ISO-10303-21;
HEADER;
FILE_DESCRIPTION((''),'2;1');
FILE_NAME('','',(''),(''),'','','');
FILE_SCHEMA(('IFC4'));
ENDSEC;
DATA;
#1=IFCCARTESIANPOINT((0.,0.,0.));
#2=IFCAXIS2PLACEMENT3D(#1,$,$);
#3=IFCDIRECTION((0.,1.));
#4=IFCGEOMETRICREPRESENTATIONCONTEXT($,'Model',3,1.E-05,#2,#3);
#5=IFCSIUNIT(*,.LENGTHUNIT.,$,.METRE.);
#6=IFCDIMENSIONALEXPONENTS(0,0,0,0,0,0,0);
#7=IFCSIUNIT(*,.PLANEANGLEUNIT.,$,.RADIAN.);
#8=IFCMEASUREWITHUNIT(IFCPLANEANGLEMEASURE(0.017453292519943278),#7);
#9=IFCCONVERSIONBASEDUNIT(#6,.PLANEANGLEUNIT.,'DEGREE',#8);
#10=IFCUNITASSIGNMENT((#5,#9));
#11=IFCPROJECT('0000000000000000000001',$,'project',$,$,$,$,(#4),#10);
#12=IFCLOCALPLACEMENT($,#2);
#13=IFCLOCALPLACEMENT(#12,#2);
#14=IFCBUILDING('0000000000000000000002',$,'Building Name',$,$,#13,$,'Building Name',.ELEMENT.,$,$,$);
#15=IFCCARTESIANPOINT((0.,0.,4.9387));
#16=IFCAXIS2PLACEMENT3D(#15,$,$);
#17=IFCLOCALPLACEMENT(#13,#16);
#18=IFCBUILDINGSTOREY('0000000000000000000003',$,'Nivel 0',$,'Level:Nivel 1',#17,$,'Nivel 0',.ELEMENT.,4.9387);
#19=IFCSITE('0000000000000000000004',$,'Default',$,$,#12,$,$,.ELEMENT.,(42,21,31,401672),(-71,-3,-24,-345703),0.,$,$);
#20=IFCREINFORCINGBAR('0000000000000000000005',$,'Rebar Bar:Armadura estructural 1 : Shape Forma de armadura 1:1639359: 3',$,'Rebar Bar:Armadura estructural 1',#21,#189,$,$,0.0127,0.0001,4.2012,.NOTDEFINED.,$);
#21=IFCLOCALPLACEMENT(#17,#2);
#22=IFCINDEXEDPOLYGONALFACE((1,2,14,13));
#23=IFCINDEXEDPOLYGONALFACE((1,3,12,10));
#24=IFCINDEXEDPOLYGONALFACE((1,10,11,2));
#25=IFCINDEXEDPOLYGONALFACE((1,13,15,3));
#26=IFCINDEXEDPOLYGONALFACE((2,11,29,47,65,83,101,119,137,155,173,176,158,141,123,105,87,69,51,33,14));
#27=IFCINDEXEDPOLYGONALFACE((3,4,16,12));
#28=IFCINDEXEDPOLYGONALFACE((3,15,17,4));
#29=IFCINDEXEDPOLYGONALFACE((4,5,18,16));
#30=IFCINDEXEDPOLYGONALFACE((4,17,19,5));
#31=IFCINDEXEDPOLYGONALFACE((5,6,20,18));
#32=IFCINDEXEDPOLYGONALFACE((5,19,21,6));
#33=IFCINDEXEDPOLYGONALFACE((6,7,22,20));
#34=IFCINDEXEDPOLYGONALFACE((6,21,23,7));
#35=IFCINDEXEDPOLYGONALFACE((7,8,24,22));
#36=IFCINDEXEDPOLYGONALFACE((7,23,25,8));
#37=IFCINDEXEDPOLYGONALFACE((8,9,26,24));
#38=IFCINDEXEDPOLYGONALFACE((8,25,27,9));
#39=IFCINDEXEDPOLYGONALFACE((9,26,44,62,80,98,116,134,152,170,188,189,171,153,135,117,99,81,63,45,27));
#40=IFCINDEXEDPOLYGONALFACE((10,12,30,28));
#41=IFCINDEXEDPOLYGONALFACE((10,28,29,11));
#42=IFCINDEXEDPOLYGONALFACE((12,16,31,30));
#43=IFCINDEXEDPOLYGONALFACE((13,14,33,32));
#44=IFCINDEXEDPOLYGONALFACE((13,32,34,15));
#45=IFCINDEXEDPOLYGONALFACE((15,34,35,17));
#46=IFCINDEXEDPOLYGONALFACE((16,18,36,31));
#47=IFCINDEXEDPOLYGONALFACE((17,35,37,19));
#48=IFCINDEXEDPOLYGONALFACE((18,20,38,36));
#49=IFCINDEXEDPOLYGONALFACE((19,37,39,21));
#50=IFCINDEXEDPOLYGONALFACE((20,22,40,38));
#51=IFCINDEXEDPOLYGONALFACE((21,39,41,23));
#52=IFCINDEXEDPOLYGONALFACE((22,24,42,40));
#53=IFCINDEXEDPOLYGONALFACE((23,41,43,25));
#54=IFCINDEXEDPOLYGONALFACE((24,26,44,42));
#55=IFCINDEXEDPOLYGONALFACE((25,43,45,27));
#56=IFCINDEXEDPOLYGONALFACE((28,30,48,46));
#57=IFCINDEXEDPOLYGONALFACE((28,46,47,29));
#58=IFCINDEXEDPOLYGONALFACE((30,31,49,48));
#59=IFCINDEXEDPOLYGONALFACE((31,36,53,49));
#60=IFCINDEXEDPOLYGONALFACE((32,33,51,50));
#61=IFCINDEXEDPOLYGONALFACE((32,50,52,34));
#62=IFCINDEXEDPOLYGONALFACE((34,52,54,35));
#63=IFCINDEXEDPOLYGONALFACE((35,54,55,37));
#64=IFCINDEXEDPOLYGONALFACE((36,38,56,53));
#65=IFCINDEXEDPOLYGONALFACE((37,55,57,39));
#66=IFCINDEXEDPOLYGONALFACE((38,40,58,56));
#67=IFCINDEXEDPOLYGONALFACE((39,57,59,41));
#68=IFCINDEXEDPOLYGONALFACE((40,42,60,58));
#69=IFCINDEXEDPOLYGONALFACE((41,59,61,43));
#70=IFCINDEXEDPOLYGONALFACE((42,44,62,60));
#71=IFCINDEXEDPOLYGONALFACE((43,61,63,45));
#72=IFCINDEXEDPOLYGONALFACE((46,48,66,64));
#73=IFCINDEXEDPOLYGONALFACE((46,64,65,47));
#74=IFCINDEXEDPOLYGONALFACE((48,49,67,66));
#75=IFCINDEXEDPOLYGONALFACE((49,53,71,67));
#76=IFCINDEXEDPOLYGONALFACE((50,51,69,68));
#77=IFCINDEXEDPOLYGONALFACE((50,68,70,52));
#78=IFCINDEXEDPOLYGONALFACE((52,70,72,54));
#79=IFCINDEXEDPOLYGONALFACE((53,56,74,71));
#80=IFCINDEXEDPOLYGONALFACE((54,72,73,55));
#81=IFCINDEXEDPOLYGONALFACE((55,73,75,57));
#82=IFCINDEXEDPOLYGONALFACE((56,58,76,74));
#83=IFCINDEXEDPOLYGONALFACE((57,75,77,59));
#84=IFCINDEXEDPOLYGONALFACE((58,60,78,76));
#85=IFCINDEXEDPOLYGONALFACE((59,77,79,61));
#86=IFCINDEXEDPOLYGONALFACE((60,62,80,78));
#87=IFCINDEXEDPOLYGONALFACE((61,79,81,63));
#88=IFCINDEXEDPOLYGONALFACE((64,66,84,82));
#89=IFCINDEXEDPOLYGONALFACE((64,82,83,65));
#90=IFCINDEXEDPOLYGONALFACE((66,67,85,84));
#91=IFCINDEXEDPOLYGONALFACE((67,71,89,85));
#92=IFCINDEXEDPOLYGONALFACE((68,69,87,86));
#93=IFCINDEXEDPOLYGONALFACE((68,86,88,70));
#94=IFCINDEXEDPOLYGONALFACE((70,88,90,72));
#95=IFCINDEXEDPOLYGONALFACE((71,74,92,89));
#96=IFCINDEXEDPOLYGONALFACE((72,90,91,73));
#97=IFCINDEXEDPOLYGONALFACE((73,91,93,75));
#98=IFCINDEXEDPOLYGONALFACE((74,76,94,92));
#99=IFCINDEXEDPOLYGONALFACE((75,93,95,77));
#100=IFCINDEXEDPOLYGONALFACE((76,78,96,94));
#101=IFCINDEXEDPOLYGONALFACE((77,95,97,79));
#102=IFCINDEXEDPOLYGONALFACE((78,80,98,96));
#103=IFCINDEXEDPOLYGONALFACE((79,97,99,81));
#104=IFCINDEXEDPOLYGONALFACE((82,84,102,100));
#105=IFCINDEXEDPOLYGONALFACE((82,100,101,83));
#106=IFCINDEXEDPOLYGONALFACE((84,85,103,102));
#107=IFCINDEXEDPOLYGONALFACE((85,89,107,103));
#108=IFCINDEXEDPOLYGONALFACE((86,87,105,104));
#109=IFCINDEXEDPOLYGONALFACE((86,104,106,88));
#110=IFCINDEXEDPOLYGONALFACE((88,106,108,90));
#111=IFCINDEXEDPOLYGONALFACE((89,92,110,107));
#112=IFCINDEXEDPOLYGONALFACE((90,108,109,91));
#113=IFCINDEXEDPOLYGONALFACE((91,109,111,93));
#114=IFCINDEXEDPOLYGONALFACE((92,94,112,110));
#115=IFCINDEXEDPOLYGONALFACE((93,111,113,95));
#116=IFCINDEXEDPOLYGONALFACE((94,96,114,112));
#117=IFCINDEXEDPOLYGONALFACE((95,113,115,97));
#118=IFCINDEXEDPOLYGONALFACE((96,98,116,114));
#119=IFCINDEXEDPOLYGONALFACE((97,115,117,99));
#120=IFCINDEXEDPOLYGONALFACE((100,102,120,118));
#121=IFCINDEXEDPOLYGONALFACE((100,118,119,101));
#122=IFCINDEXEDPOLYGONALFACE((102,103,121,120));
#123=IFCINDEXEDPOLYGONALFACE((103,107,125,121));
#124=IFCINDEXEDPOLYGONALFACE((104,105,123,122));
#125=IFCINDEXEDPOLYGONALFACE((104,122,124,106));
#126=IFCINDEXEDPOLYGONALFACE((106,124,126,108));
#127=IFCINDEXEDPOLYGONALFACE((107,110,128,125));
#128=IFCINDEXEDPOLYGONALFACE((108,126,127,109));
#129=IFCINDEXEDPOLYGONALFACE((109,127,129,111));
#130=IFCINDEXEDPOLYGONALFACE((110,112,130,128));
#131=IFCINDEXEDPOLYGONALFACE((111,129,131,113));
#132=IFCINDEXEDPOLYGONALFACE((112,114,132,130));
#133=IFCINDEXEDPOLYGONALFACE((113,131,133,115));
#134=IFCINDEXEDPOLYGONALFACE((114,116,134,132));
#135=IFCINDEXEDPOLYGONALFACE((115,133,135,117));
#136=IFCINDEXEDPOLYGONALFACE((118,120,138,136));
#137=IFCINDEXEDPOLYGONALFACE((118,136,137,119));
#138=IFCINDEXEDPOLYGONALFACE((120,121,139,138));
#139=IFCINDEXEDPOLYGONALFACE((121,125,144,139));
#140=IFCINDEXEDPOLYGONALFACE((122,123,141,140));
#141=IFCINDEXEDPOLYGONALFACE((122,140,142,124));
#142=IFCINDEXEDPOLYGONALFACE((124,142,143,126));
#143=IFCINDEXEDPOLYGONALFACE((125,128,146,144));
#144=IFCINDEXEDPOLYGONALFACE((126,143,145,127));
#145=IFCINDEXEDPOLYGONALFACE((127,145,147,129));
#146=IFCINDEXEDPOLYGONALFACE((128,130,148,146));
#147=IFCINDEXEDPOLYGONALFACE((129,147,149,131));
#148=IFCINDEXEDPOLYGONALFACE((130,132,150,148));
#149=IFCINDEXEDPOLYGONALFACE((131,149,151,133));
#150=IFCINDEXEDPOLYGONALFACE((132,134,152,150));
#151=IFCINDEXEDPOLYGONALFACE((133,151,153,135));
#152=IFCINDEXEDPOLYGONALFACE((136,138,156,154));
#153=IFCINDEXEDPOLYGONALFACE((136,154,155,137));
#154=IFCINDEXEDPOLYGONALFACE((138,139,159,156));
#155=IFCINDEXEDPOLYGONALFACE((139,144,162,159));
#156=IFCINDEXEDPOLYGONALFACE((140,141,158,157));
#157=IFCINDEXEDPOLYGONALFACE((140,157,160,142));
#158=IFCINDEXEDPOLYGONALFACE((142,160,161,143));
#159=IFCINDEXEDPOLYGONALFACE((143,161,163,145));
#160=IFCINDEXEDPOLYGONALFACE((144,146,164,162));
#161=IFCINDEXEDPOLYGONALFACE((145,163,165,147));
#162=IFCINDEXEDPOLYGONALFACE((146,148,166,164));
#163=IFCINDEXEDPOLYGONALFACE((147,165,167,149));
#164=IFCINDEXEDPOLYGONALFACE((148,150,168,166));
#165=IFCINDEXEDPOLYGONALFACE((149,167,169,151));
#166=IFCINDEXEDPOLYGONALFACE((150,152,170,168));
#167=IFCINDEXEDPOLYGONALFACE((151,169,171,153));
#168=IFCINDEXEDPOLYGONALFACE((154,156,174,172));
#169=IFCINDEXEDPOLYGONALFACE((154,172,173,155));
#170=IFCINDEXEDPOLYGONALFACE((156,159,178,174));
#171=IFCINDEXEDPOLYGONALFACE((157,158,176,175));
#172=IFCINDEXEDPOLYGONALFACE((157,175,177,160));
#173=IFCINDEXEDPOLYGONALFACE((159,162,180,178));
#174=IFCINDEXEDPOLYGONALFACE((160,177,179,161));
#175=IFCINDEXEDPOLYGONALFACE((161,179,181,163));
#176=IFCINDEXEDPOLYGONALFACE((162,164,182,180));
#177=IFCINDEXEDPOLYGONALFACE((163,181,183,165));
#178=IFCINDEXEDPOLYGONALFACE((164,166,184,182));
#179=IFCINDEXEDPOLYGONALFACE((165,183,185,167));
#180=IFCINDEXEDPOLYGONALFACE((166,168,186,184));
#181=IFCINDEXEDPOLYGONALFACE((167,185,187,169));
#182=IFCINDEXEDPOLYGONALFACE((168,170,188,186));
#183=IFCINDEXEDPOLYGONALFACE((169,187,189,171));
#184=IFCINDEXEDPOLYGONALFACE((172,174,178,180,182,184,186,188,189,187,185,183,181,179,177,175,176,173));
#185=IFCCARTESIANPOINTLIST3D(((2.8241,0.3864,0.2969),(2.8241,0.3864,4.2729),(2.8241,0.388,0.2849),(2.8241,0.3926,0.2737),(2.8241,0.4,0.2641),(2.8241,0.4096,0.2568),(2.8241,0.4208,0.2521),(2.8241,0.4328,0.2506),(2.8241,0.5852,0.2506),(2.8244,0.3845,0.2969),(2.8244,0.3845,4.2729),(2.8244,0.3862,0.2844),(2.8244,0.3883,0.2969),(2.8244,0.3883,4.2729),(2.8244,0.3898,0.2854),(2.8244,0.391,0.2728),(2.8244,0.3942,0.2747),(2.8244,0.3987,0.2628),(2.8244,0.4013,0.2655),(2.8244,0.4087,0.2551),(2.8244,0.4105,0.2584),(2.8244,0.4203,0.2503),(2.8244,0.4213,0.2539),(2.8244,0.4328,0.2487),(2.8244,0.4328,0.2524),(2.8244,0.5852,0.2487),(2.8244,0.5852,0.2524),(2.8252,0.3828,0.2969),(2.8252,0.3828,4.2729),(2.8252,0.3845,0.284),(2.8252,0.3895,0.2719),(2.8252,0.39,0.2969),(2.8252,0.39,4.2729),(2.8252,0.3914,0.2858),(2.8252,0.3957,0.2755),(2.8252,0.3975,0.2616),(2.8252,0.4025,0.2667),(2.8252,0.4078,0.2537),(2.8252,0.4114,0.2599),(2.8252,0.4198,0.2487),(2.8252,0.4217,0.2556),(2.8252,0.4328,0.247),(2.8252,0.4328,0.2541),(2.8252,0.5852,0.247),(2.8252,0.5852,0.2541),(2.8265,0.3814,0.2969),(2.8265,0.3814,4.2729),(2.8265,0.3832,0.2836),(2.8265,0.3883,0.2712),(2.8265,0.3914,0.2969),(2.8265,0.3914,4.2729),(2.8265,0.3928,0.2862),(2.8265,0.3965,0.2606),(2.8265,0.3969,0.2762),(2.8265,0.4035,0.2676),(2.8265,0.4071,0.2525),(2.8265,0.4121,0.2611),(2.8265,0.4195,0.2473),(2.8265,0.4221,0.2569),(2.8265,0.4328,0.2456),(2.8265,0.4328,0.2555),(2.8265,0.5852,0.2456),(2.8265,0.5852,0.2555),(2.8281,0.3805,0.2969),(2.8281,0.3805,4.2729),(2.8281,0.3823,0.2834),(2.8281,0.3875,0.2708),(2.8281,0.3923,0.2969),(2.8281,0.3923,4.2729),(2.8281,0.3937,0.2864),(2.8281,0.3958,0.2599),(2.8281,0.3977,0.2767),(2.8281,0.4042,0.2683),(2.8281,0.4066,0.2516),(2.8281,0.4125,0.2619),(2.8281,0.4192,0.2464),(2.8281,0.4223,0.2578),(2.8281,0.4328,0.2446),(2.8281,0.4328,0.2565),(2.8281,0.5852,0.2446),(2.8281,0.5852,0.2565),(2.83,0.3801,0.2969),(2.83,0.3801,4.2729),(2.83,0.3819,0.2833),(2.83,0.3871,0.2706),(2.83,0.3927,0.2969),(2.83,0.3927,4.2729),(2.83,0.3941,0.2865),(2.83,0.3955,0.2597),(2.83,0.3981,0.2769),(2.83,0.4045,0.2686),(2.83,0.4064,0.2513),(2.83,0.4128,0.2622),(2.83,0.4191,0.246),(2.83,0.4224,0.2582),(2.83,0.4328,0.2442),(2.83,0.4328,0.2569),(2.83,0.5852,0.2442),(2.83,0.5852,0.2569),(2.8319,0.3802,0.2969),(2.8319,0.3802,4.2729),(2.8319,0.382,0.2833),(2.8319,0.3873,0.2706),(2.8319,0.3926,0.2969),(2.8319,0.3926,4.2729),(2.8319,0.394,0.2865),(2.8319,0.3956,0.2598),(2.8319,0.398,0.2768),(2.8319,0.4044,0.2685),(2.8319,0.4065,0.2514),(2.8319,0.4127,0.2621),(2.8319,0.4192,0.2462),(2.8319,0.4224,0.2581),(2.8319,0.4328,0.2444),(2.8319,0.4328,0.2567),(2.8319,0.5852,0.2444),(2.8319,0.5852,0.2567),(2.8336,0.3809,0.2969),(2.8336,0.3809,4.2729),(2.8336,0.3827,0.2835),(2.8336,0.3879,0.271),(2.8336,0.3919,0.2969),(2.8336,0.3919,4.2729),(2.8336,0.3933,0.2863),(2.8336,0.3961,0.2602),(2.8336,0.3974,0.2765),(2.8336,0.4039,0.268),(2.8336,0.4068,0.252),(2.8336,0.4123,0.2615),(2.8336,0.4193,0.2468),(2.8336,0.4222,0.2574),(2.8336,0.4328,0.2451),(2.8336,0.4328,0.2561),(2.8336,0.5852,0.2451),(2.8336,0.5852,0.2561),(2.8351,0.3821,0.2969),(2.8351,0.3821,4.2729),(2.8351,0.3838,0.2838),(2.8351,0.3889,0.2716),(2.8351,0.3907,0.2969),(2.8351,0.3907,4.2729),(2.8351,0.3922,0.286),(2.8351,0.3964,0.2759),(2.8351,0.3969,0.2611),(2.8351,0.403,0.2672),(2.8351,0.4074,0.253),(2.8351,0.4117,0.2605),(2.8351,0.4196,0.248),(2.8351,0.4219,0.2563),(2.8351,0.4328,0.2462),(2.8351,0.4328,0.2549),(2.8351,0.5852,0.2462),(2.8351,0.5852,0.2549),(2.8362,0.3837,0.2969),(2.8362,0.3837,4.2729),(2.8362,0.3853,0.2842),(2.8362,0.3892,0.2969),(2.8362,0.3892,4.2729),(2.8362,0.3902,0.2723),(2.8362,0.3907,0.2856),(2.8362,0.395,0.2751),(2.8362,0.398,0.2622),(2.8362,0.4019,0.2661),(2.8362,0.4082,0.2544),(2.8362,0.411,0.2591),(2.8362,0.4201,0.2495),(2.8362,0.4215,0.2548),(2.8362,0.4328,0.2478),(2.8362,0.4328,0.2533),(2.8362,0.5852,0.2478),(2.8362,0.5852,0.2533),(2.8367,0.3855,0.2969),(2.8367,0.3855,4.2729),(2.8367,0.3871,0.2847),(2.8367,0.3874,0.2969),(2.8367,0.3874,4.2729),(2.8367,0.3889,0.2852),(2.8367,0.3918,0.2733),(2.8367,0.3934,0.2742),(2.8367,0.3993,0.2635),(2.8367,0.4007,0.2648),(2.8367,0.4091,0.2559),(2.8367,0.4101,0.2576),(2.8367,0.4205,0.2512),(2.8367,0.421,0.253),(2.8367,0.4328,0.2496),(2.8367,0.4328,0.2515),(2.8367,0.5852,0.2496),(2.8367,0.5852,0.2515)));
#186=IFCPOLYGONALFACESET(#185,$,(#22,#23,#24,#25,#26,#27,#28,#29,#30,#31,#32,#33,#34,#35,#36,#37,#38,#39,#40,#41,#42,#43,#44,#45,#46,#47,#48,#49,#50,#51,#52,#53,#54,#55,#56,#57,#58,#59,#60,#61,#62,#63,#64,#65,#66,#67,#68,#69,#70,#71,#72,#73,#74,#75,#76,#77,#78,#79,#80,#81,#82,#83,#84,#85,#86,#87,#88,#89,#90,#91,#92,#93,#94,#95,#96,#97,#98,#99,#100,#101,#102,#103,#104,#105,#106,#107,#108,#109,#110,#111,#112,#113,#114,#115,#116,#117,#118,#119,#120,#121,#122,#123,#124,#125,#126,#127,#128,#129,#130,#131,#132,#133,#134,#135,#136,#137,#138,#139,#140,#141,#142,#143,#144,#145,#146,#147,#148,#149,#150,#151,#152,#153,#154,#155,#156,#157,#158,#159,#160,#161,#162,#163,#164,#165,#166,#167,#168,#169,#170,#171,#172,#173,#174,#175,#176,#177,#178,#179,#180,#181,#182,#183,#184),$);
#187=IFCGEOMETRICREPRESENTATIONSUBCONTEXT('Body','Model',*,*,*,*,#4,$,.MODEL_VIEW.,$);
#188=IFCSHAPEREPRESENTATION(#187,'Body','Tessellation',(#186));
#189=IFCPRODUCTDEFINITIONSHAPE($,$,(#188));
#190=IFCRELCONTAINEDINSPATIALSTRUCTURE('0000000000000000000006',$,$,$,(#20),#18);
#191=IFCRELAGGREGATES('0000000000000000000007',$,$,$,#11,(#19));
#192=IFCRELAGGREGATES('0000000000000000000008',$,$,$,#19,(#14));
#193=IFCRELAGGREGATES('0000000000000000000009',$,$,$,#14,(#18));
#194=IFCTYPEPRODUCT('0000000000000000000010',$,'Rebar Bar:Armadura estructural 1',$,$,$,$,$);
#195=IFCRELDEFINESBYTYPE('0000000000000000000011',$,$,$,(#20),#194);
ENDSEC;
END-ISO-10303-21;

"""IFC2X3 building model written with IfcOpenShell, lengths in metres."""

from ifc_helpers import new_model, entity, si_unit, converted_unit, direction, frame, origin, place, context, subcontext, project, spatial, type_object, element, save


model = new_model("IFC2X3")

# Units and contexts
model_context = context("Model", 3, precision=1e-05, world=origin(), true_north=direction((0.0, 1.0)))
body_context = subcontext(model_context, "Body", "Model", "MODEL_VIEW")
ifc_project = project(units=[si_unit("LENGTHUNIT", "METRE"), converted_unit("PLANEANGLEUNIT", "DEGREE", entity("IfcPlaneAngleMeasure", 0.017453292519943278), si_unit("PLANEANGLEUNIT", "RADIAN"), dimensions=[0, 0, 0, 0, 0, 0, 0])], contexts=[model_context])

# Site, building, storey
site_placement = place(None, origin())
site = spatial("IfcSite", under=ifc_project, at=site_placement, Name="Default", CompositionType="ELEMENT", RefLatitude=(42, 21, 31, 401672), RefLongitude=(-71, -3, -24, -345703), RefElevation=0.0)
building_placement = place(site_placement, origin())
building = spatial("IfcBuilding", under=site, at=building_placement, Name="Building Name", LongName="Building Name", CompositionType="ELEMENT")
storey_placement = place(building_placement, frame((0.0, 0.0, 4.9387)))
storey = spatial("IfcBuildingStorey", under=building, at=storey_placement, Name="Nivel 0", ObjectType="Level:Nivel 1", LongName="Nivel 0", CompositionType="ELEMENT", Elevation=4.9387)

# Reinforcing bar
type_product = type_object("IfcTypeProduct", Name="Rebar Bar:Armadura estructural 1")
reinforcing_bar_1_placement = place(storey_placement, origin())
element("IfcReinforcingBar", 1, at=reinforcing_bar_1_placement, inside=storey, type_object=type_product, Name="Rebar Bar:Armadura estructural 1 : Shape Forma de armadura 1:1639359: 3", ObjectType="Rebar Bar:Armadura estructural 1", BarLength=4.2012, BarRole="NOTDEFINED", CrossSectionArea=0.0001, NominalDiameter=0.0127, context=body_context, shape_type="AdvancedSweptSolid", body=[
    entity("IfcSweptDiskSolid", entity("IfcCompositeCurve", [entity("IfcCompositeCurveSegment", "CONTINUOUS", True, entity("IfcPolyline", [entity("IfcCartesianPoint", [2.8305, 0.5852, 0.2506]), entity("IfcCartesianPoint", [2.8305, 0.4328, 0.2506])])), entity("IfcCompositeCurveSegment", "CONTINUOUS", True, entity("IfcTrimmedCurve", entity("IfcCircle", entity("IfcAxis2Placement3D", entity("IfcCartesianPoint", [2.8305, 0.4328, 0.2969]), entity("IfcDirection", [-1.0, 0.0, 0.0]), entity("IfcDirection", [0.0, -1.0, 0.0])), 0.0464), [entity("IfcParameterValue", 270.0)], [entity("IfcParameterValue", 360.0)], True, "PARAMETER")), entity("IfcCompositeCurveSegment", "CONTINUOUS", True, entity("IfcPolyline", [entity("IfcCartesianPoint", [2.8305, 0.3864, 0.2969]), entity("IfcCartesianPoint", [2.8305, 0.3864, 4.2729])]))], False), 0.0063, None, 0.0, 92.0),
])

save(model, "model.ifc")
